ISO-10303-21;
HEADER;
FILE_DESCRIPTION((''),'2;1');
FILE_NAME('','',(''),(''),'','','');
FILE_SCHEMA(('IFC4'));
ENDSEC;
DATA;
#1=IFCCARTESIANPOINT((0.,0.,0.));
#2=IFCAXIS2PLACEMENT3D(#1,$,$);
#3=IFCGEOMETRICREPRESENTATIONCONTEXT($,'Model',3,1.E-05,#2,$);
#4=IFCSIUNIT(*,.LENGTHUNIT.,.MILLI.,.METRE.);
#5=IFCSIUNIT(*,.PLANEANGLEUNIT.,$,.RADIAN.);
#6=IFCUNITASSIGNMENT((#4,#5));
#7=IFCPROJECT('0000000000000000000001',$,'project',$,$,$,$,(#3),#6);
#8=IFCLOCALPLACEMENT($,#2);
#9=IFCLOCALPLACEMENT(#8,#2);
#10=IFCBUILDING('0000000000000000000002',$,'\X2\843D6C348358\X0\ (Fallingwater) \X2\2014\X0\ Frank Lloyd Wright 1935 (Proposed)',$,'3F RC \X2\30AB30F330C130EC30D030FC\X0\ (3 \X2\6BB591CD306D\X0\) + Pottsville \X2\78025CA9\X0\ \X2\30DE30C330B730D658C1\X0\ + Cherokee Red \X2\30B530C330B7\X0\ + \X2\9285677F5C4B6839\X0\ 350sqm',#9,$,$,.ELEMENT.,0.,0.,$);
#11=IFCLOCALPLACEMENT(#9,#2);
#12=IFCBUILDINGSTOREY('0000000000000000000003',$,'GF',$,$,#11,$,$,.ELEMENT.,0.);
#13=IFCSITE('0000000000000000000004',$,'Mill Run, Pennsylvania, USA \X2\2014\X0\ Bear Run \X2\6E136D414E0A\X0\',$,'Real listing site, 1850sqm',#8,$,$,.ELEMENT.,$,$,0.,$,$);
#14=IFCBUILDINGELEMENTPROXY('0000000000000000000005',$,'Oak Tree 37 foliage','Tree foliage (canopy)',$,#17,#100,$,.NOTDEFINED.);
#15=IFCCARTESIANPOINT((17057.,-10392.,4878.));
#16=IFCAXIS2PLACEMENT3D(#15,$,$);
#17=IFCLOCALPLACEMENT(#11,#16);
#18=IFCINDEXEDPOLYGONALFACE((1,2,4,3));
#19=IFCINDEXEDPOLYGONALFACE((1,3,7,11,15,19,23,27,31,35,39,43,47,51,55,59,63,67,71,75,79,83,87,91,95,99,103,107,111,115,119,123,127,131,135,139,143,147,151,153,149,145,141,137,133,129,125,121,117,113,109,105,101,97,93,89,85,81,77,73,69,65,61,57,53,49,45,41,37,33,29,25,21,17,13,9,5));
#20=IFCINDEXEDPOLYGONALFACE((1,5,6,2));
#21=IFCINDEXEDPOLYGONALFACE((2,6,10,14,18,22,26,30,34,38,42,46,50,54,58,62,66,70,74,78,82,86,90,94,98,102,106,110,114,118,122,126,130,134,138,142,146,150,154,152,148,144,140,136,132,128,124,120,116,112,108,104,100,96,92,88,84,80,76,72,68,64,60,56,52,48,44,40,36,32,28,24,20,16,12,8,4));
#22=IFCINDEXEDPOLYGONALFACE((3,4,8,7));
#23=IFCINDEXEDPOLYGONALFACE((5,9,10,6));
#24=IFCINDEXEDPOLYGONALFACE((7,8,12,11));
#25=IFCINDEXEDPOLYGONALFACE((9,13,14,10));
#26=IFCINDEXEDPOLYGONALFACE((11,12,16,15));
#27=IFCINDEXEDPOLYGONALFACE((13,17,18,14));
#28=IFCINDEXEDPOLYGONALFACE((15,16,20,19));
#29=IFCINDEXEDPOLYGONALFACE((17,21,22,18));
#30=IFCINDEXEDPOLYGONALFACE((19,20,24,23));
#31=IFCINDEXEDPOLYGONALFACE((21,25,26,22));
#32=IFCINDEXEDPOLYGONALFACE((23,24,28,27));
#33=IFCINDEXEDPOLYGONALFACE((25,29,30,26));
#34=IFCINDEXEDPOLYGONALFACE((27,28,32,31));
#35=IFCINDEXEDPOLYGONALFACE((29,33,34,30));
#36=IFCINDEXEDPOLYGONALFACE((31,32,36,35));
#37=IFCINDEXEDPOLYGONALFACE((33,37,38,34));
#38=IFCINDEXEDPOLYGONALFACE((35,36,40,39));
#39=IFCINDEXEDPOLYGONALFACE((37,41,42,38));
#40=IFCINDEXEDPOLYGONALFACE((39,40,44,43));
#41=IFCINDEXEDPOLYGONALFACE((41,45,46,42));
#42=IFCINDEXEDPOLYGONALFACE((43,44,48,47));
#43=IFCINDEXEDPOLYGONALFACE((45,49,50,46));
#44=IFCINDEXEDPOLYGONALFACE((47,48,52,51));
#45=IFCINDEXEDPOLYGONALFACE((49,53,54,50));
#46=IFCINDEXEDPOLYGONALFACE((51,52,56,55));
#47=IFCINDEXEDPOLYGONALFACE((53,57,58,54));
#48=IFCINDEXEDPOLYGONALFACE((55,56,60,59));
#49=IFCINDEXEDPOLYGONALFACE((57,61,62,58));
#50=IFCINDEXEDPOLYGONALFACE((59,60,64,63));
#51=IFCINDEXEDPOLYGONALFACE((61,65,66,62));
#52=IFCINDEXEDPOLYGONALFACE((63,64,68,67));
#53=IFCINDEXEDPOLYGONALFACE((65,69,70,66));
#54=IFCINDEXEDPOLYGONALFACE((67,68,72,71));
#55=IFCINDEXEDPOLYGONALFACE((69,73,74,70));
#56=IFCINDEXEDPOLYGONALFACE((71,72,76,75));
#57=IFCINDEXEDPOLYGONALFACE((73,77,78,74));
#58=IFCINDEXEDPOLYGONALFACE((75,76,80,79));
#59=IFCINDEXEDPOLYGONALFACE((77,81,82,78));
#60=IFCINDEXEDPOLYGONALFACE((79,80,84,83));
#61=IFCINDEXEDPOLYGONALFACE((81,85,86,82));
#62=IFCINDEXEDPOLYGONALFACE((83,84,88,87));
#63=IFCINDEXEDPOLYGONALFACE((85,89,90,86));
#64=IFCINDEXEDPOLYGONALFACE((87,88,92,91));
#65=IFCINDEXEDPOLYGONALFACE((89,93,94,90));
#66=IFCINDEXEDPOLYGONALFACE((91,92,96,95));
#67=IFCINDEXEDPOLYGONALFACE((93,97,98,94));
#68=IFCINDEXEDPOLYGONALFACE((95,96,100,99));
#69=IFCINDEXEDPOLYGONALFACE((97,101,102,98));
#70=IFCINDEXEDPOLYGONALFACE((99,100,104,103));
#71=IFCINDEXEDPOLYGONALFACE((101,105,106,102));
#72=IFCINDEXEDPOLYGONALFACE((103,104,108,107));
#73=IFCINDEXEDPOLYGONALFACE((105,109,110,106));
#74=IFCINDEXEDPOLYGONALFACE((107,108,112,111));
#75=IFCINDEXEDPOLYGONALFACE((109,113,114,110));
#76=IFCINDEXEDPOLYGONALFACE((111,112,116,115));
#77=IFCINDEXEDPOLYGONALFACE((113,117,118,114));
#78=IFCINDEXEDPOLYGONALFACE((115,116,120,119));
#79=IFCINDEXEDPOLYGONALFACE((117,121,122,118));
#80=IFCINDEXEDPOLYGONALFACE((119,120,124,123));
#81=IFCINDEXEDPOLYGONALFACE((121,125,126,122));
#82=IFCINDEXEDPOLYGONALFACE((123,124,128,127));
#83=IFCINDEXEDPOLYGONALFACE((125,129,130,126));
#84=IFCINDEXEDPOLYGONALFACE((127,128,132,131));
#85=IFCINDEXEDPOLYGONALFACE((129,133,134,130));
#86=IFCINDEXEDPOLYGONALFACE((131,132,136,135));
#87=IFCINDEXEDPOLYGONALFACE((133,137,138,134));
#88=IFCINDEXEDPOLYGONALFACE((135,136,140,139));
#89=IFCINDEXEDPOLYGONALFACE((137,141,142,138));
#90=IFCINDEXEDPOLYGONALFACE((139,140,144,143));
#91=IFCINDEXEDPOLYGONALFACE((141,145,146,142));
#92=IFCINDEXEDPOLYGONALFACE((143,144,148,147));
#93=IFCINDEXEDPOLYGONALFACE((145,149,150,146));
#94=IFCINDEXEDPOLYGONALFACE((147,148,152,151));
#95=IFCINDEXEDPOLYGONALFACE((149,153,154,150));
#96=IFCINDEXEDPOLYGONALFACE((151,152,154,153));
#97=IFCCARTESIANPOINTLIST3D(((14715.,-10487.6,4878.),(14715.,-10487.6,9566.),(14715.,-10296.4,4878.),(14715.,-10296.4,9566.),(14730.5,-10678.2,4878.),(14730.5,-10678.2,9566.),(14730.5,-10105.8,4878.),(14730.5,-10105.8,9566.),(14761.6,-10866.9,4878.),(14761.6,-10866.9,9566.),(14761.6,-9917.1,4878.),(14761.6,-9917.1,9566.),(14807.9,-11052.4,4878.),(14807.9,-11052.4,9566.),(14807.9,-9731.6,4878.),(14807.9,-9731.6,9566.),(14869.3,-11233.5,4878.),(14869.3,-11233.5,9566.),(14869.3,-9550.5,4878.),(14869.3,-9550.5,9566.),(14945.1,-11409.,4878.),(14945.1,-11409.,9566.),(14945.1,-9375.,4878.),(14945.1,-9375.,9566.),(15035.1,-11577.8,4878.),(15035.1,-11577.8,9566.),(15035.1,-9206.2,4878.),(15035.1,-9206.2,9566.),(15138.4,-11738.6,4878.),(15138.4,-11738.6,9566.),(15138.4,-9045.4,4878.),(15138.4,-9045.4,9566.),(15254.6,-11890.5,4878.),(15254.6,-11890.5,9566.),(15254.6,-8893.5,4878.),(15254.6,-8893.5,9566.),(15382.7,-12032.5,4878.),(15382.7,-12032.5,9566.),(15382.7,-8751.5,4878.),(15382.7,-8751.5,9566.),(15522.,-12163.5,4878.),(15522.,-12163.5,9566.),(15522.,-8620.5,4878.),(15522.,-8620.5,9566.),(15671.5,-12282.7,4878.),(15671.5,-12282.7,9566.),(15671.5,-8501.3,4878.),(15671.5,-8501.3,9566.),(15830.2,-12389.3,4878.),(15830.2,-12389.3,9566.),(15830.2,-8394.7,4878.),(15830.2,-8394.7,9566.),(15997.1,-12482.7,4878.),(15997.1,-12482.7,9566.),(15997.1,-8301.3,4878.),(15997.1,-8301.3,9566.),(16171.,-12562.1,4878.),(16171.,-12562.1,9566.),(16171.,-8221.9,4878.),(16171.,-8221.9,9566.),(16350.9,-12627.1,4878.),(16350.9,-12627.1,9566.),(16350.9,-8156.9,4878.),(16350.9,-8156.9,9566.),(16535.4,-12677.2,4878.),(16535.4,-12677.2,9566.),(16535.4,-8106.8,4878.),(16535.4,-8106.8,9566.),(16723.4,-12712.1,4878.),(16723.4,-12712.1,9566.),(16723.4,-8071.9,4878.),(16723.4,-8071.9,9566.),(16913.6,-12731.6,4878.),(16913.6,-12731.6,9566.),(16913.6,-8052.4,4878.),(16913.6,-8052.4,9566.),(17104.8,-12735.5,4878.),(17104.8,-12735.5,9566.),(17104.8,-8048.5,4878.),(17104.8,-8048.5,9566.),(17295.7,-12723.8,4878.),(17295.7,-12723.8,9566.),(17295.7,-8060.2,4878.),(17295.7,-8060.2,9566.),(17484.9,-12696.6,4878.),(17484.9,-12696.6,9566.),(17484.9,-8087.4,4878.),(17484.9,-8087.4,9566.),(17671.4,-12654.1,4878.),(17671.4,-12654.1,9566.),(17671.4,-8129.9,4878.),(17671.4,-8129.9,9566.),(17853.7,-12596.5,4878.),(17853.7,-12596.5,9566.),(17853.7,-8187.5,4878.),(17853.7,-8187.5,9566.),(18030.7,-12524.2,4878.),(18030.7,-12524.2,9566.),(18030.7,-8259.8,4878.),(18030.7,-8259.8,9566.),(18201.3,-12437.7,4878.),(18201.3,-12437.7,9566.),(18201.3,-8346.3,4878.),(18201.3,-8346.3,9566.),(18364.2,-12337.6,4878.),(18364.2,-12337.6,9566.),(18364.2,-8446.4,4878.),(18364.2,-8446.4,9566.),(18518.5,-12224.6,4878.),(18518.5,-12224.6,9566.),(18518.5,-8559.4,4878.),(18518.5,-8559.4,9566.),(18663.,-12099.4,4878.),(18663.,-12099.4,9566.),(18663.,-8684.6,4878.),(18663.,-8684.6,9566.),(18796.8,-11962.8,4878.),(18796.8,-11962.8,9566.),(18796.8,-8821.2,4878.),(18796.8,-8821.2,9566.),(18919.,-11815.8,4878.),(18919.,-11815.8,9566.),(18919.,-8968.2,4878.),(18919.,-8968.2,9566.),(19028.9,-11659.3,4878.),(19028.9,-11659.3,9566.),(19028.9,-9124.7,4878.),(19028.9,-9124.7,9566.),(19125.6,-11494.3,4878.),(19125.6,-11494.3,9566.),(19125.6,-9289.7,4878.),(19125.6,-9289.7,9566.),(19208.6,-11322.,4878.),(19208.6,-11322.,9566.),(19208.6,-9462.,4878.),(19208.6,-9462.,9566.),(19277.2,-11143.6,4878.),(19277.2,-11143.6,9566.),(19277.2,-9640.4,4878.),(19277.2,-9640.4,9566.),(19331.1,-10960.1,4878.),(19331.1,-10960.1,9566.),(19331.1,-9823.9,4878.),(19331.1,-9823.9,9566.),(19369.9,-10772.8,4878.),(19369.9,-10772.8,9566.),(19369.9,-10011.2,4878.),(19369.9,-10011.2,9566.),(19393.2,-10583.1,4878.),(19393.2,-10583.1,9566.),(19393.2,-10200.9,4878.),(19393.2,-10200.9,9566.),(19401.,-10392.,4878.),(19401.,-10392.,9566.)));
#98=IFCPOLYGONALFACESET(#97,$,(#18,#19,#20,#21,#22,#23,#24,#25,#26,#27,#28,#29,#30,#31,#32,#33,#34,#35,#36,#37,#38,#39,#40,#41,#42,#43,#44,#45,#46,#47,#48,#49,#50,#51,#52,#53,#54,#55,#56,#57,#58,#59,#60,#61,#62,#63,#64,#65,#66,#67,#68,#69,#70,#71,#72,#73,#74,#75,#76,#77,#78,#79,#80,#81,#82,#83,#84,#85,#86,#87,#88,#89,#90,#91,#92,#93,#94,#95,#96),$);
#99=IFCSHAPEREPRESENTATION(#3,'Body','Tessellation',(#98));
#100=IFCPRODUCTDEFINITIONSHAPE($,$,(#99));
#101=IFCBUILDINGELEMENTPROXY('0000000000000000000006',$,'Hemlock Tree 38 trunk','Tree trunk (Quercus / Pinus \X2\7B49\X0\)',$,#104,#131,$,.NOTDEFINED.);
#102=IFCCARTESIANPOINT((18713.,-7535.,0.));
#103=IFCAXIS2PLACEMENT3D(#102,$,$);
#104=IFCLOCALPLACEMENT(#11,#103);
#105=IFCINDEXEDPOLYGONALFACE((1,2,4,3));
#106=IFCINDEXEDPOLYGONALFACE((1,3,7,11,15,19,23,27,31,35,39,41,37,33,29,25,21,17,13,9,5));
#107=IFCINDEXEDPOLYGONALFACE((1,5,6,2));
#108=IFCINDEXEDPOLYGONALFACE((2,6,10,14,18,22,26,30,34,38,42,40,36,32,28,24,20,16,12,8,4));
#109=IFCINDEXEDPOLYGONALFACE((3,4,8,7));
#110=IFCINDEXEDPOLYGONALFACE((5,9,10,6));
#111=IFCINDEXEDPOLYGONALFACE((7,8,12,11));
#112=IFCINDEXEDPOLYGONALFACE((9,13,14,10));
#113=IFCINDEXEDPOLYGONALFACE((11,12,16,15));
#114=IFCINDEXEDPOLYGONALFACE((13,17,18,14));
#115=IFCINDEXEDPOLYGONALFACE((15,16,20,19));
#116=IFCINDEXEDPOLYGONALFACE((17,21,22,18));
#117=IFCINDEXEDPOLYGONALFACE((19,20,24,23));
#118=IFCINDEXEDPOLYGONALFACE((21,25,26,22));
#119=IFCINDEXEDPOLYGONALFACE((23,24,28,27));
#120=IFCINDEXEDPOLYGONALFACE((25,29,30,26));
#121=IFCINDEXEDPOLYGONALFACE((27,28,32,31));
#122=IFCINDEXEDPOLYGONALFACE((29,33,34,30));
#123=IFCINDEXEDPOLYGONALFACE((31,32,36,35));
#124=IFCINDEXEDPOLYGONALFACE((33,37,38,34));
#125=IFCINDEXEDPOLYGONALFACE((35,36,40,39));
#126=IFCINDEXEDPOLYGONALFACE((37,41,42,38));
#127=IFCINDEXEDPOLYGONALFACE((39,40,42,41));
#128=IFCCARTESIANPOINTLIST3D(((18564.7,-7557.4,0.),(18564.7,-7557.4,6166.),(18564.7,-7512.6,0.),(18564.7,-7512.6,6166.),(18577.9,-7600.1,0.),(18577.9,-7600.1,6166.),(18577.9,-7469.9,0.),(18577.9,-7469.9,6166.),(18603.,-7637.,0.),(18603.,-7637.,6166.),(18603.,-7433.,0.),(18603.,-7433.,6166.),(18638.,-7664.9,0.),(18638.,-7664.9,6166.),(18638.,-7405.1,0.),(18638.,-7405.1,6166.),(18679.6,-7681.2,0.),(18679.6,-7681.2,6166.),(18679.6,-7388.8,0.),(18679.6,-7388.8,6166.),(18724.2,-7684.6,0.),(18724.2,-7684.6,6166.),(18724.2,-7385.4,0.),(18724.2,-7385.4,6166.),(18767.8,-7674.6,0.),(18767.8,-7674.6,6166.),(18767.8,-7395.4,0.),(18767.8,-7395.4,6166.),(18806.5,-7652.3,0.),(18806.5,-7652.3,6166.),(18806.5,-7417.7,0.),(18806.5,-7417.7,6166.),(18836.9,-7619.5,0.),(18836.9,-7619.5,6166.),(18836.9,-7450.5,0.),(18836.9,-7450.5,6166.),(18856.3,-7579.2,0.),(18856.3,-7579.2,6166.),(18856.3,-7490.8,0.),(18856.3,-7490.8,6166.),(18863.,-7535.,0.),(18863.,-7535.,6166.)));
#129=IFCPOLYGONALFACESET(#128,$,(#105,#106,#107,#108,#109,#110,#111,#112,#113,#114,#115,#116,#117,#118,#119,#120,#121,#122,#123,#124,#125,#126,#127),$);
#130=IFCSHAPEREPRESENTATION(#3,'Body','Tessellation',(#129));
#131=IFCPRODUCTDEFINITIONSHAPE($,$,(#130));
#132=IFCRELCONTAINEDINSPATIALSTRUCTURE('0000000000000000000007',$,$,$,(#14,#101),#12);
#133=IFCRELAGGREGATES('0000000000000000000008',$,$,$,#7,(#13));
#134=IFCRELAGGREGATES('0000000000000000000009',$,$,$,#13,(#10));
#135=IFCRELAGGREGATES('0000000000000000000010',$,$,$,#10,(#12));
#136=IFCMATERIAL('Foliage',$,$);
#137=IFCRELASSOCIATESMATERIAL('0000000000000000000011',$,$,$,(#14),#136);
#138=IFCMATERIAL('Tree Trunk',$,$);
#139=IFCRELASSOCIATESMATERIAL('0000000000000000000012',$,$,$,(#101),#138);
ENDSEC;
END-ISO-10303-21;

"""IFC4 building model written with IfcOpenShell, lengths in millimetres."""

from ifc_helpers import new_model, si_unit, frame, origin, origin_2d, place, context, project, spatial, circle, extrude, material, element, save


model = new_model("IFC4")

# Units and contexts
model_context = context("Model", 3, precision=1e-05, world=origin())
ifc_project = project(units=[si_unit("LENGTHUNIT", "METRE", prefix="MILLI"), si_unit("PLANEANGLEUNIT", "RADIAN")], contexts=[model_context])

# Site, building, storey
site_placement = place(None, origin())
site = spatial("IfcSite", under=ifc_project, at=site_placement, Name="Mill Run, Pennsylvania, USA — Bear Run 渓流上", ObjectType="Real listing site, 1850sqm", CompositionType="ELEMENT", RefElevation=0.0)
building_placement = place(site_placement, origin())
building = spatial("IfcBuilding", under=site, at=building_placement, Name="落水荘 (Fallingwater) — Frank Lloyd Wright 1935 (Proposed)", ObjectType="3F RC カンチレバー (3 段重ね) + Pottsville 砂岩 マッシブ壁 + Cherokee Red サッシ + 銅板屋根 350sqm", CompositionType="ELEMENT", ElevationOfRefHeight=0.0, ElevationOfTerrain=0.0)
storey_placement = place(building_placement, origin())
storey = spatial("IfcBuildingStorey", under=building, at=storey_placement, Name="GF", CompositionType="ELEMENT", Elevation=0.0)

# Building element proxies
ifc_material_1 = material(Name="Tree Trunk")
ifc_material_2 = material(Name="Foliage")
proxy_1_placement = place(storey_placement, frame((17057.0, -10392.0, 4878.0)))
element("IfcBuildingElementProxy", 1, at=proxy_1_placement, inside=storey, material=ifc_material_2, Name="Oak Tree 37 foliage", Description="Tree foliage (canopy)", PredefinedType="NOTDEFINED", context=model_context, shape_type="SweptSolid", body=[
    extrude(circle(Radius=2344.0, at=origin_2d()), frame((17057.0, -10392.0, 4878.0)), (0.0, 0.0, 1.0), 4688.0),
])
proxy_2_placement = place(storey_placement, frame((18713.0, -7535.0, 0.0)))
element("IfcBuildingElementProxy", 2, at=proxy_2_placement, inside=storey, material=ifc_material_1, Name="Hemlock Tree 38 trunk", Description="Tree trunk (Quercus / Pinus 等)", PredefinedType="NOTDEFINED", context=model_context, shape_type="SweptSolid", body=[
    extrude(circle(Radius=150.0, at=origin_2d()), frame((18713.0, -7535.0, 0.0)), (0.0, 0.0, 1.0), 6166.0),
])

save(model, "model.ifc")
